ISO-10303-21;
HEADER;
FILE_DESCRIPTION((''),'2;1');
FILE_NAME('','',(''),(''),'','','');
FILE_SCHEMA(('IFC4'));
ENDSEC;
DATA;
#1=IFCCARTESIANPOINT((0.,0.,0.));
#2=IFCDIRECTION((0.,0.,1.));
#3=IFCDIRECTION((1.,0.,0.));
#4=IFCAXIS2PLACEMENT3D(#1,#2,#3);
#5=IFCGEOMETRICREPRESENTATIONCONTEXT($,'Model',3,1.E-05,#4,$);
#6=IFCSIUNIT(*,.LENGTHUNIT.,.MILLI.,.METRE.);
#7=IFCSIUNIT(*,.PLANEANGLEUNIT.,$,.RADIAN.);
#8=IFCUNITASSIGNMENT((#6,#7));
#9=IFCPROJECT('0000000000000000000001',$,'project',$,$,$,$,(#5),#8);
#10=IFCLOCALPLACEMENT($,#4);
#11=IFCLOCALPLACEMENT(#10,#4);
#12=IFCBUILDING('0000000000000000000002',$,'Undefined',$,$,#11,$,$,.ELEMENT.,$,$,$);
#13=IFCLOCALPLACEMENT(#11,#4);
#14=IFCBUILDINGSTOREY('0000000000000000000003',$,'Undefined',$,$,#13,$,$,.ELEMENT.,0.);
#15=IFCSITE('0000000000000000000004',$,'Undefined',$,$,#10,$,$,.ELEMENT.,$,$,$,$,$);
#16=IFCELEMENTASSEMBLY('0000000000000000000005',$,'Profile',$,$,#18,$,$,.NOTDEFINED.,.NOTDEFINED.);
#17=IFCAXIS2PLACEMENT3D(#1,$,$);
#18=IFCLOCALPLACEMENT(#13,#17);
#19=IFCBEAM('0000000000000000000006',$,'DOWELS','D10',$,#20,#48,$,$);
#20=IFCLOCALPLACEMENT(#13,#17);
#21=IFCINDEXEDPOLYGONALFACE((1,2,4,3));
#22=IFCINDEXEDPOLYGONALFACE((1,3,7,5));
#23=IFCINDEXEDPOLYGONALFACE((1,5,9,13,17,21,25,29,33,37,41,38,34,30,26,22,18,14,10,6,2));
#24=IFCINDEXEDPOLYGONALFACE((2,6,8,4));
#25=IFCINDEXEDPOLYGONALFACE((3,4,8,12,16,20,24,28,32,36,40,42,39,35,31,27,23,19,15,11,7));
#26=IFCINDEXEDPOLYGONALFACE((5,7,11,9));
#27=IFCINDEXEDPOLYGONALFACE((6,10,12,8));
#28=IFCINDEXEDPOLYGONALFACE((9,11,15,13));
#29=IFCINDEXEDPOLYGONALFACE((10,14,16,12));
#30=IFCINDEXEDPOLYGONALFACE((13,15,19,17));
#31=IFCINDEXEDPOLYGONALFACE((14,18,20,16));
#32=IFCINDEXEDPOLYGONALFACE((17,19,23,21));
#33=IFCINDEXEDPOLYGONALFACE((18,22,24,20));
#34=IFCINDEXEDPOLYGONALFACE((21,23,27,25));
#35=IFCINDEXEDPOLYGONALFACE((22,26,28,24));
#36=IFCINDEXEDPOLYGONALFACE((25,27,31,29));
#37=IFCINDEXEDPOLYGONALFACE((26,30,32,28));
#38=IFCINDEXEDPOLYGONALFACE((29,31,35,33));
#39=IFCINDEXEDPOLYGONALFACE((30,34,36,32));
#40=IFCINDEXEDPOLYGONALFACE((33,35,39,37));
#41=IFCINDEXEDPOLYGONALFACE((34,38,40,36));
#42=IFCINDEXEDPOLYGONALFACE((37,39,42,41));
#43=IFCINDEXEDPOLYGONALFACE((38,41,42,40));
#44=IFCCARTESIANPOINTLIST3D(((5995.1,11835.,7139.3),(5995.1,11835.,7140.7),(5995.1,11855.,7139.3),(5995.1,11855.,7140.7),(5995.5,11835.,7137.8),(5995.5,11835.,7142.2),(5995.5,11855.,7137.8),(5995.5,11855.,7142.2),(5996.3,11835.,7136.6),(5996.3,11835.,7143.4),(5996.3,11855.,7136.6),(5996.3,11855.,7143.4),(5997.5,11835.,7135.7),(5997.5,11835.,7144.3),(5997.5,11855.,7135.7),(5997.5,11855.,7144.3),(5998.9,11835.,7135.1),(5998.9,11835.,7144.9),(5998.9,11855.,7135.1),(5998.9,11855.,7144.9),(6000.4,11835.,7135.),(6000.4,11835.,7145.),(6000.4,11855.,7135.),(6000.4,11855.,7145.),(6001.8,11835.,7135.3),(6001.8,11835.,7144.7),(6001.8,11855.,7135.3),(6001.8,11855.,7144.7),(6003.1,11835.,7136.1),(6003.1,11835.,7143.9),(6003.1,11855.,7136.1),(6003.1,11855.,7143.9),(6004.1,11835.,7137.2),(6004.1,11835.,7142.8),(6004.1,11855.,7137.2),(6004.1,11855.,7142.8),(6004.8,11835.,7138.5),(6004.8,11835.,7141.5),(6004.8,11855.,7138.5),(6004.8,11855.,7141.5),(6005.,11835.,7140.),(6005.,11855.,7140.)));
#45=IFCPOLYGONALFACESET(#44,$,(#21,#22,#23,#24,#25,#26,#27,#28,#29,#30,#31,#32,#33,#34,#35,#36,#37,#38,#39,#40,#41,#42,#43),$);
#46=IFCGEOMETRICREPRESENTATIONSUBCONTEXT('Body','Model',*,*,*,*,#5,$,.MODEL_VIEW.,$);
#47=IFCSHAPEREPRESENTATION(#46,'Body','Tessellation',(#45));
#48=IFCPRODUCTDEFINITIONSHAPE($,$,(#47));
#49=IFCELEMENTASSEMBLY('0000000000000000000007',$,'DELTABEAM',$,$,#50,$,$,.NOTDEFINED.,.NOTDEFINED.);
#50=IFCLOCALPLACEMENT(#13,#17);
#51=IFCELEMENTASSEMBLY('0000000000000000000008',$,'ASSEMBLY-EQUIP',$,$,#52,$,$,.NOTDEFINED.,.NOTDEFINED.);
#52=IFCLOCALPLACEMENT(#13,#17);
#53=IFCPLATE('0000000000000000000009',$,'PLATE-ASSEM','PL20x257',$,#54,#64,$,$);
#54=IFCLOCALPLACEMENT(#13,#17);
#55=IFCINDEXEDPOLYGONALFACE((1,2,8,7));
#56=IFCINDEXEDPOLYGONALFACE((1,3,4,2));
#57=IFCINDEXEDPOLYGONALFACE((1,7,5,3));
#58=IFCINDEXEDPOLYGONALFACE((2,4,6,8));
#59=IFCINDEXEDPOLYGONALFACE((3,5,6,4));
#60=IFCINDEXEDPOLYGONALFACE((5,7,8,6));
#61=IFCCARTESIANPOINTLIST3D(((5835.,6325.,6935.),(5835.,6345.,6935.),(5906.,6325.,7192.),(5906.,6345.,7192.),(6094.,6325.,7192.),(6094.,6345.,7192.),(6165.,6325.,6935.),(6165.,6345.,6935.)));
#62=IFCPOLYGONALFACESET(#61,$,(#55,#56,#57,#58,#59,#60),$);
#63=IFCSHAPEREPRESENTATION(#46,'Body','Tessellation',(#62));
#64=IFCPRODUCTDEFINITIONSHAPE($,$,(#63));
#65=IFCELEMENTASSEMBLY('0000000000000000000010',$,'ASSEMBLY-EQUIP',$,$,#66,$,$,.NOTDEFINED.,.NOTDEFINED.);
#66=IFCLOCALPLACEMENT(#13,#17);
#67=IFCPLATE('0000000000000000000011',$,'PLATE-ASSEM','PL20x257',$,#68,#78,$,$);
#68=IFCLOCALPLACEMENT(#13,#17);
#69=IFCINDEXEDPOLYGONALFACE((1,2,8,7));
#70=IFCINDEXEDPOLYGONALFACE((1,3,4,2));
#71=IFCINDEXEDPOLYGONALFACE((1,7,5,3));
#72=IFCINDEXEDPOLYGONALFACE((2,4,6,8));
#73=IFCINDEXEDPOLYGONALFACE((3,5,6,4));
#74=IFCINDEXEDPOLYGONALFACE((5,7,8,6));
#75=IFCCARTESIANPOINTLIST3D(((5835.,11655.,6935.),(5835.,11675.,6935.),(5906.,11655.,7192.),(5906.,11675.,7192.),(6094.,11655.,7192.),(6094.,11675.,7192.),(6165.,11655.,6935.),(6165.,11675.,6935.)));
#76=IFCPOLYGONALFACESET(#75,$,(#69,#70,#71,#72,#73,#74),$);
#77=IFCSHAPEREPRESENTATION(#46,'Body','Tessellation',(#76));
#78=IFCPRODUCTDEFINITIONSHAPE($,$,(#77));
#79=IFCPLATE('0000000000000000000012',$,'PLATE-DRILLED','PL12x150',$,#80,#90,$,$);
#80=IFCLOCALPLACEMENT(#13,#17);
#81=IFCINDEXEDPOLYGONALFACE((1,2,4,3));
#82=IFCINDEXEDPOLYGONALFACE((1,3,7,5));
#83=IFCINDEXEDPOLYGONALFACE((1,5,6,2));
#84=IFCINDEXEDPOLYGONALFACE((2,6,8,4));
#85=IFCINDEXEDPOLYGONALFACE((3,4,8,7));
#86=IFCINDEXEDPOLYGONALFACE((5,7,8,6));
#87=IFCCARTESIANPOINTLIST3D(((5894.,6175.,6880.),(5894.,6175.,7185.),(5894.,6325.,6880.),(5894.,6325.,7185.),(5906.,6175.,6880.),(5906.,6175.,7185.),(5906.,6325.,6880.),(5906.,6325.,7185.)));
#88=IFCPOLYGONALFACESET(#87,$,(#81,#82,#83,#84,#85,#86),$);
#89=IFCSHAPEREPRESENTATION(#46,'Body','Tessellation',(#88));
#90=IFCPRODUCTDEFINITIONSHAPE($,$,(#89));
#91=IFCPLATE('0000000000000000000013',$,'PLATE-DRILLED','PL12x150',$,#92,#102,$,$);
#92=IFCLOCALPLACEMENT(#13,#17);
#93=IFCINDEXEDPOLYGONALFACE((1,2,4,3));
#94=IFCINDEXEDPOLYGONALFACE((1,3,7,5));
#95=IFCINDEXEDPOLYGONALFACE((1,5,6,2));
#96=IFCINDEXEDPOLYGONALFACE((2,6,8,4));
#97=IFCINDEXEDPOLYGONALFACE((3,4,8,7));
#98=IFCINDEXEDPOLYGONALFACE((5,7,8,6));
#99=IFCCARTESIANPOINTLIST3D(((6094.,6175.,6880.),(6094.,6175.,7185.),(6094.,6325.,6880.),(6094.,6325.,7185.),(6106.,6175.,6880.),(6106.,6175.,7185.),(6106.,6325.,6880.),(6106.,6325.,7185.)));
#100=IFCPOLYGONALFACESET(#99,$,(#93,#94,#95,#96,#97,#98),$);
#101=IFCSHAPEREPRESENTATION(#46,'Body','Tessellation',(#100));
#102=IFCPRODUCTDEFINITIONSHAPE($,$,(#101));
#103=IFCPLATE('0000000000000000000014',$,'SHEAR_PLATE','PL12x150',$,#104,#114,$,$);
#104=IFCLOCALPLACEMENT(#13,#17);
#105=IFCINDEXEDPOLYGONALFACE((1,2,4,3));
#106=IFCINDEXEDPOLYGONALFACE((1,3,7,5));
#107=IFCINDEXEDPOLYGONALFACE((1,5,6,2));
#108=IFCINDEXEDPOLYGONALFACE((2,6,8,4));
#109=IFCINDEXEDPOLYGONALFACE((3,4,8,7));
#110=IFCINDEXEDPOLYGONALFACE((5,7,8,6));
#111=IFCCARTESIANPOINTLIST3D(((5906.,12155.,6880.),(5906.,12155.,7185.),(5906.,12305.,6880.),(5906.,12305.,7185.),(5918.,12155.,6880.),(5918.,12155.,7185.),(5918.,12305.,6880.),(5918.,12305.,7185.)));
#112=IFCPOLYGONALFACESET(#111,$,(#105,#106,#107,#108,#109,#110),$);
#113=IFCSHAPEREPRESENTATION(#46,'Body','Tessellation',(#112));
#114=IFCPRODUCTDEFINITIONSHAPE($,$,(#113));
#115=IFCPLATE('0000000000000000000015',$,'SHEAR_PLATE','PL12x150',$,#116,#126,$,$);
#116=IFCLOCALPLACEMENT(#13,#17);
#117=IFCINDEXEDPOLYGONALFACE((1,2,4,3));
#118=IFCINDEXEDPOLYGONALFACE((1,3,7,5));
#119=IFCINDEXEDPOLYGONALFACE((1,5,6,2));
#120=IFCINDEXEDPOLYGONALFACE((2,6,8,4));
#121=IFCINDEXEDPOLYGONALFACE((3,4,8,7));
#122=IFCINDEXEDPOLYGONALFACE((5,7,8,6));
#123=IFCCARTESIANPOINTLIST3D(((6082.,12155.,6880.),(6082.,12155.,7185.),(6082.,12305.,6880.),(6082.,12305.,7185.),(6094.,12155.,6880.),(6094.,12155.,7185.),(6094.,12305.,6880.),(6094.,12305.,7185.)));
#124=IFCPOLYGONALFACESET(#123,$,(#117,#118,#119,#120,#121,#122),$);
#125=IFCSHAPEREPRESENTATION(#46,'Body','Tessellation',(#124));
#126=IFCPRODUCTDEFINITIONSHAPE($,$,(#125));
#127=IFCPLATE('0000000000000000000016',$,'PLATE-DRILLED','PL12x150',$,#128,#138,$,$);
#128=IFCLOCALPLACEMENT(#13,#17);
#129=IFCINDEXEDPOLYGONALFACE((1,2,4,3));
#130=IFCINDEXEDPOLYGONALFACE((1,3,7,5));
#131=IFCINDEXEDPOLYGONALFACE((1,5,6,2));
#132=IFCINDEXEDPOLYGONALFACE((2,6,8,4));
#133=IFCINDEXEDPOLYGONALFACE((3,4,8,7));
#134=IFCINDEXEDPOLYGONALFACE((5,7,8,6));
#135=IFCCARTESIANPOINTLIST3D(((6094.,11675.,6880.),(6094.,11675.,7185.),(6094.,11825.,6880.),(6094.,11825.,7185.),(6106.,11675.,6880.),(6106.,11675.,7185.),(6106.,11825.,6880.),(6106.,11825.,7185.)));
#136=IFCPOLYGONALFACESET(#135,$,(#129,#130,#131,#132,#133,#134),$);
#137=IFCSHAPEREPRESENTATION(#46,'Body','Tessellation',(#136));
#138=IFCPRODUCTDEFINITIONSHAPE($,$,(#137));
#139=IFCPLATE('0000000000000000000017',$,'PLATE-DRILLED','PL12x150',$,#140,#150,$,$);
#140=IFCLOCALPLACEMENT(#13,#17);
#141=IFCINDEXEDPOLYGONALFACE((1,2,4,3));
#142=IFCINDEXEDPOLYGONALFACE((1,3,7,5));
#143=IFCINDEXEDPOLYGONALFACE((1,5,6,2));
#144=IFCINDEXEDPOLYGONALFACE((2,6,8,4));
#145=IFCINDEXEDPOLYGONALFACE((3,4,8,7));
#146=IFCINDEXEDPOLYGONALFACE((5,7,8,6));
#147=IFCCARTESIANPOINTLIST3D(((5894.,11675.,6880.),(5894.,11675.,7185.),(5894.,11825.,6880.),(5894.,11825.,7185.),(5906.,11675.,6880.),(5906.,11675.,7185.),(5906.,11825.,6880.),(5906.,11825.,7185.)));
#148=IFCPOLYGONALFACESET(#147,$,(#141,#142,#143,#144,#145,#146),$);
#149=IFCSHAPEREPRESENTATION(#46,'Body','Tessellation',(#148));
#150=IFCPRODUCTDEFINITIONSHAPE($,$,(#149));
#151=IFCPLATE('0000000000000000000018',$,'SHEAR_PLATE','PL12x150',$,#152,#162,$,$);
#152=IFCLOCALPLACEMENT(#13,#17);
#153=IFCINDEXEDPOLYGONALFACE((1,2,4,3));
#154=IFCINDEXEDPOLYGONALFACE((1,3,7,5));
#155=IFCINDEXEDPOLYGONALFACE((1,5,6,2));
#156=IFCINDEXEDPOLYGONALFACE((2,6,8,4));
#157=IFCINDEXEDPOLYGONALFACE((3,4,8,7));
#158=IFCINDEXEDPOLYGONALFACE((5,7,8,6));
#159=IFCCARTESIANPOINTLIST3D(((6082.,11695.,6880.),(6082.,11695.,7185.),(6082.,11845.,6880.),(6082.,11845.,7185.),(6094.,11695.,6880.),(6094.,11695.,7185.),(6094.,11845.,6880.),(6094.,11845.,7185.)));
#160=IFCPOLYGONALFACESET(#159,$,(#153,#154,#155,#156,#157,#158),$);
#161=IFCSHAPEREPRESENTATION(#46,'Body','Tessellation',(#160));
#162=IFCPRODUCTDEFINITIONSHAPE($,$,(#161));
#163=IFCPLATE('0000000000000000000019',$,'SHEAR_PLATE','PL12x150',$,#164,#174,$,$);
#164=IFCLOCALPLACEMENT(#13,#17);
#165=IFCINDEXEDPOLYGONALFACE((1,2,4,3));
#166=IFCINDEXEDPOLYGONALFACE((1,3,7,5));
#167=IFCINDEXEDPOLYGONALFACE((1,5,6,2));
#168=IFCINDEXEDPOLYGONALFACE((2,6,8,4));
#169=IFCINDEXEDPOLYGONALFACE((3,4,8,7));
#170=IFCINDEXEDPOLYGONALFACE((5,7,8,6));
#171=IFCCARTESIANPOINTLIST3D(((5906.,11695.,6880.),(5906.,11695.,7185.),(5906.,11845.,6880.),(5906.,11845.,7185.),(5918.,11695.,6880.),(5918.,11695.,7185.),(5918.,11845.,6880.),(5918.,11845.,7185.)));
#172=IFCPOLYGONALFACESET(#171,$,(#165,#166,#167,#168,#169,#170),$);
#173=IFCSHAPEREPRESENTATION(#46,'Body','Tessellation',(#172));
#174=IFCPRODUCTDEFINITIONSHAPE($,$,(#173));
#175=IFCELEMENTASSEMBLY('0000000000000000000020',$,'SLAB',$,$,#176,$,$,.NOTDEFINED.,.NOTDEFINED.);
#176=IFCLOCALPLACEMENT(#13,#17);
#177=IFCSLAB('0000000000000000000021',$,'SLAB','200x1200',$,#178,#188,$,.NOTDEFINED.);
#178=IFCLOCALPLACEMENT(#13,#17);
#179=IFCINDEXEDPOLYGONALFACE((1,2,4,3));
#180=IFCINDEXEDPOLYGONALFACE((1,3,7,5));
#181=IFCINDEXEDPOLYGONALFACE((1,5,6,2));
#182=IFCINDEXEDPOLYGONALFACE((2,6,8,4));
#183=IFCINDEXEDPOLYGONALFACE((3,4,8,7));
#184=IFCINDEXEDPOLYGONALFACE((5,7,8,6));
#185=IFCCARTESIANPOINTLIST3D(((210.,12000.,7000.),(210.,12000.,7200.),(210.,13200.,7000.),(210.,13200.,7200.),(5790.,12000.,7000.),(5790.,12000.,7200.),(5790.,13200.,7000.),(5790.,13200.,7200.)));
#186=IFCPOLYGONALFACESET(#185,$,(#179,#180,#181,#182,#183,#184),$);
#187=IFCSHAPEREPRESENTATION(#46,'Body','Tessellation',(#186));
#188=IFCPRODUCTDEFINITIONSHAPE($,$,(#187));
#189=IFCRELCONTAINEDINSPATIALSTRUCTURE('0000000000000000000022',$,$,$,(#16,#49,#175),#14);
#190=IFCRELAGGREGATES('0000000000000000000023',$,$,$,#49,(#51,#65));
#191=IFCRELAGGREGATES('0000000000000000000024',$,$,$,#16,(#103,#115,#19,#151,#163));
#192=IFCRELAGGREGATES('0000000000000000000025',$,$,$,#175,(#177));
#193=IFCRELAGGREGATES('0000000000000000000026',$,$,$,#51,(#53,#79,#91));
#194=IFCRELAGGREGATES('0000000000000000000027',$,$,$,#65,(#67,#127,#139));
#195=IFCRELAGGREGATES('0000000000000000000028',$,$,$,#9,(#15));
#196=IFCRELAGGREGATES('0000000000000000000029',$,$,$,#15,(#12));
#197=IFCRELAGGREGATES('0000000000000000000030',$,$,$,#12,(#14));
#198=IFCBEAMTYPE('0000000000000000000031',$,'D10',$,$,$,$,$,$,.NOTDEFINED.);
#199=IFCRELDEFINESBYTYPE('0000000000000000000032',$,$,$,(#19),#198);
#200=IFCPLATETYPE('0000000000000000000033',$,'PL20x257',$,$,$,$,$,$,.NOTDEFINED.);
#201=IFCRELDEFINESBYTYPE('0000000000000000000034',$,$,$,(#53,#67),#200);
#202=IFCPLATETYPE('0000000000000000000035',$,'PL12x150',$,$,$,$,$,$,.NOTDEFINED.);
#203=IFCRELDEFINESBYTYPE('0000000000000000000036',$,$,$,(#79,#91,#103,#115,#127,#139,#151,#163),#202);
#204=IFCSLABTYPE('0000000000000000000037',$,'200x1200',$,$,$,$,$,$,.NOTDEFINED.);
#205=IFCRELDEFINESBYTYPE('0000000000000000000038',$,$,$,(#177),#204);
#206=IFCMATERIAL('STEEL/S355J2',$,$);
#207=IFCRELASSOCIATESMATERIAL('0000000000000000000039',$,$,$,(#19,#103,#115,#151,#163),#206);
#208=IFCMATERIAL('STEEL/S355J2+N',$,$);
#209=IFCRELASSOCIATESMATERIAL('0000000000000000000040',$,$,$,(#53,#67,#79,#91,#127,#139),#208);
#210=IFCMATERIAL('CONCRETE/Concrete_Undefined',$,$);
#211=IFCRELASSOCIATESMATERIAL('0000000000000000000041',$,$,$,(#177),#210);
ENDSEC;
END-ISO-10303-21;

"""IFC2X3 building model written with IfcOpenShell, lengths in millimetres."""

from ifc_helpers import new_model, si_unit, frame, origin_with_axes, origin_2d_with_axis, place, context, subcontext, project, spatial, polyline, circle, outline, extrude, material, type_object, element, aggregate, save


model = new_model("IFC2X3")

# Units and contexts
model_context = context("Model", 3, precision=1e-05, world=origin_with_axes())
body_context = subcontext(model_context, "Body", "Model", "MODEL_VIEW")
ifc_project = project(units=[si_unit("LENGTHUNIT", "METRE", prefix="MILLI"), si_unit("PLANEANGLEUNIT", "RADIAN")], contexts=[model_context])

# Site, building, storey
site_placement = place(None, origin_with_axes())
site = spatial("IfcSite", under=ifc_project, at=site_placement, Name="Undefined", CompositionType="ELEMENT")
building_placement = place(site_placement, origin_with_axes())
building = spatial("IfcBuilding", under=site, at=building_placement, Name="Undefined", CompositionType="ELEMENT")
storey_placement = place(building_placement, origin_with_axes())
storey = spatial("IfcBuildingStorey", under=building, at=storey_placement, Name="Undefined", CompositionType="ELEMENT", Elevation=0.0)

# Element assembly, beam
assembly_1_placement = place(storey_placement, origin_with_axes())
assembly_1 = element("IfcElementAssembly", 1, at=assembly_1_placement, inside=storey, Name="Profile", AssemblyPlace="NOTDEFINED", PredefinedType="NOTDEFINED")
ifc_material_1 = material(Name="STEEL/S355J2")
beam_type_1 = type_object("IfcBeamType", Name="D10", PredefinedType="NOTDEFINED")
beam_1_placement = place(assembly_1_placement, frame((6000.0, 11835.0, 7140.0), z_axis=(0.0, 0.0, 1.0), x_axis=(0.0, 1.0, 0.0)))
beam_1 = element("IfcBeam", 2, at=beam_1_placement, type_object=beam_type_1, material=ifc_material_1, Name="DOWELS", Description="D10", context=body_context, shape_type="SweptSolid", body=[
    extrude(circle(Radius=5.0, at=origin_2d_with_axis()), frame((20.0, 0.0, 0.0), z_axis=(-1.0, 0.0, 0.0), x_axis=(0.0, -1.0, 0.0)), (0.0, 0.0, 1.0), 20.0),
])

# Element assemblies, plates
assembly_2_placement = place(storey_placement, origin_with_axes())
assembly_2 = element("IfcElementAssembly", 3, at=assembly_2_placement, inside=storey, Name="DELTABEAM", AssemblyPlace="NOTDEFINED", PredefinedType="NOTDEFINED")
assembly_3_placement = place(assembly_2_placement, origin_with_axes())
assembly_3 = element("IfcElementAssembly", 4, at=assembly_3_placement, Name="ASSEMBLY-EQUIP", AssemblyPlace="NOTDEFINED", PredefinedType="NOTDEFINED")
ifc_material_2 = material(Name="STEEL/S355J2+N")
plate_type_1 = type_object("IfcPlateType", Name="PL20x257", PredefinedType="NOTDEFINED")
plate_1_placement = place(assembly_3_placement, frame((6165.0, 6335.0, 6935.0), z_axis=(0.0, 1.0, 0.0), x_axis=(-1.0, 0.0, 0.0)))
plate_1 = element("IfcPlate", 5, at=plate_1_placement, type_object=plate_type_1, material=ifc_material_2, Name="PLATE-ASSEM", Description="PL20x257", context=body_context, shape_type="SweptSolid", body=[
    extrude(outline(polyline([(0.0, 0.0), (330.0, 0.0), (259.0, 257.0), (71.0, 257.0), (0.0, 0.0)])), frame((0.0, 0.0, -10.0), z_axis=(0.0, 0.0, 1.0), x_axis=(1.0, 0.0, 0.0)), (0.0, 0.0, 1.0), 20.0),
])
assembly_4_placement = place(assembly_2_placement, origin_with_axes())
assembly_4 = element("IfcElementAssembly", 6, at=assembly_4_placement, Name="ASSEMBLY-EQUIP", AssemblyPlace="NOTDEFINED", PredefinedType="NOTDEFINED")
aggregate(assembly_2, [assembly_3, assembly_4])
plate_2_placement = place(assembly_4_placement, frame((5835.0, 11665.0, 6935.0), z_axis=(0.0, -1.0, 0.0), x_axis=(1.0, 0.0, 0.0)))
plate_2 = element("IfcPlate", 7, at=plate_2_placement, type_object=plate_type_1, material=ifc_material_2, Name="PLATE-ASSEM", Description="PL20x257", context=body_context, shape_type="SweptSolid", body=[
    extrude(outline(polyline([(0.0, 0.0), (330.0, 0.0), (259.0, 257.0), (71.0, 257.0), (0.0, 0.0)])), frame((0.0, 0.0, -10.0), z_axis=(0.0, 0.0, 1.0), x_axis=(1.0, 0.0, 0.0)), (0.0, 0.0, 1.0), 20.0),
])
plate_type_2 = type_object("IfcPlateType", Name="PL12x150", PredefinedType="NOTDEFINED")
plate_3_placement = place(assembly_3_placement, frame((5900.0, 6325.0, 7185.0), z_axis=(1.0, 0.0, 0.0), x_axis=(0.0, -1.0, 0.0)))
plate_3 = element("IfcPlate", 8, at=plate_3_placement, type_object=plate_type_2, material=ifc_material_2, Name="PLATE-DRILLED", Description="PL12x150", context=body_context, shape_type="SweptSolid", body=[
    extrude(outline(polyline([(0.0, 0.0), (150.0, 0.0), (150.0, 0.0), (150.0, 305.0), (150.0, 305.0), (0.0, 305.0), (0.0, 305.0), (0.0, 0.0)])), frame((0.0, 0.0, -6.0), z_axis=(0.0, 0.0, 1.0), x_axis=(1.0, 0.0, 0.0)), (0.0, 0.0, 1.0), 12.0),
])
plate_4_placement = place(assembly_3_placement, frame((6100.0, 6325.0, 7185.0), z_axis=(1.0, 0.0, 0.0), x_axis=(0.0, -1.0, 0.0)))
plate_4 = element("IfcPlate", 9, at=plate_4_placement, type_object=plate_type_2, material=ifc_material_2, Name="PLATE-DRILLED", Description="PL12x150", context=body_context, shape_type="SweptSolid", body=[
    extrude(outline(polyline([(0.0, 0.0), (150.0, 0.0), (150.0, 0.0), (150.0, 305.0), (150.0, 305.0), (0.0, 305.0), (0.0, 305.0), (0.0, 0.0)])), frame((0.0, 0.0, -6.0), z_axis=(0.0, 0.0, 1.0), x_axis=(1.0, 0.0, 0.0)), (0.0, 0.0, 1.0), 12.0),
])

# Plates
plate_5_placement = place(assembly_1_placement, frame((5912.0, 12155.0, 7185.0), z_axis=(-1.0, 0.0, 0.0), x_axis=(0.0, 1.0, 0.0)))
plate_5 = element("IfcPlate", 10, at=plate_5_placement, type_object=plate_type_2, material=ifc_material_1, Name="SHEAR_PLATE", Description="PL12x150", context=body_context, shape_type="SweptSolid", body=[
    extrude(outline(polyline([(0.0, 0.0), (150.0, 0.0), (150.0, 0.0), (150.0, 305.0), (150.0, 305.0), (0.0, 305.0), (0.0, 305.0), (0.0, 0.0)])), frame((0.0, 0.0, -6.0), z_axis=(0.0, 0.0, 1.0), x_axis=(1.0, 0.0, 0.0)), (0.0, 0.0, 1.0), 12.0),
])
plate_6_placement = place(assembly_1_placement, frame((6088.0, 12155.0, 7185.0), z_axis=(-1.0, 0.0, 0.0), x_axis=(0.0, 1.0, 0.0)))
plate_6 = element("IfcPlate", 11, at=plate_6_placement, type_object=plate_type_2, material=ifc_material_1, Name="SHEAR_PLATE", Description="PL12x150", context=body_context, shape_type="SweptSolid", body=[
    extrude(outline(polyline([(0.0, 0.0), (150.0, 0.0), (150.0, 0.0), (150.0, 305.0), (150.0, 305.0), (0.0, 305.0), (0.0, 305.0), (0.0, 0.0)])), frame((0.0, 0.0, -6.0), z_axis=(0.0, 0.0, 1.0), x_axis=(1.0, 0.0, 0.0)), (0.0, 0.0, 1.0), 12.0),
])
plate_7_placement = place(assembly_4_placement, frame((6100.0, 11675.0, 7185.0), z_axis=(-1.0, 0.0, 0.0), x_axis=(0.0, 1.0, 0.0)))
plate_7 = element("IfcPlate", 12, at=plate_7_placement, type_object=plate_type_2, material=ifc_material_2, Name="PLATE-DRILLED", Description="PL12x150", context=body_context, shape_type="SweptSolid", body=[
    extrude(outline(polyline([(0.0, 0.0), (150.0, 0.0), (150.0, 0.0), (150.0, 305.0), (150.0, 305.0), (0.0, 305.0), (0.0, 305.0), (0.0, 0.0)])), frame((0.0, 0.0, -6.0), z_axis=(0.0, 0.0, 1.0), x_axis=(1.0, 0.0, 0.0)), (0.0, 0.0, 1.0), 12.0),
])
plate_8_placement = place(assembly_4_placement, frame((5900.0, 11675.0, 7185.0), z_axis=(-1.0, 0.0, 0.0), x_axis=(0.0, 1.0, 0.0)))
plate_8 = element("IfcPlate", 13, at=plate_8_placement, type_object=plate_type_2, material=ifc_material_2, Name="PLATE-DRILLED", Description="PL12x150", context=body_context, shape_type="SweptSolid", body=[
    extrude(outline(polyline([(0.0, 0.0), (150.0, 0.0), (150.0, 0.0), (150.0, 305.0), (150.0, 305.0), (0.0, 305.0), (0.0, 305.0), (0.0, 0.0)])), frame((0.0, 0.0, -6.0), z_axis=(0.0, 0.0, 1.0), x_axis=(1.0, 0.0, 0.0)), (0.0, 0.0, 1.0), 12.0),
])
plate_9_placement = place(assembly_1_placement, frame((6088.0, 11845.0, 7185.0), z_axis=(1.0, 0.0, 0.0), x_axis=(0.0, -1.0, 0.0)))
plate_9 = element("IfcPlate", 14, at=plate_9_placement, type_object=plate_type_2, material=ifc_material_1, Name="SHEAR_PLATE", Description="PL12x150", context=body_context, shape_type="SweptSolid", body=[
    extrude(outline(polyline([(0.0, 0.0), (150.0, 0.0), (150.0, 0.0), (150.0, 305.0), (150.0, 305.0), (0.0, 305.0), (0.0, 305.0), (0.0, 0.0)])), frame((0.0, 0.0, -6.0), z_axis=(0.0, 0.0, 1.0), x_axis=(1.0, 0.0, 0.0)), (0.0, 0.0, 1.0), 12.0),
])
plate_10_placement = place(assembly_1_placement, frame((5912.0, 11845.0, 7185.0), z_axis=(1.0, 0.0, 0.0), x_axis=(0.0, -1.0, 0.0)))
plate_10 = element("IfcPlate", 15, at=plate_10_placement, type_object=plate_type_2, material=ifc_material_1, Name="SHEAR_PLATE", Description="PL12x150", context=body_context, shape_type="SweptSolid", body=[
    extrude(outline(polyline([(0.0, 0.0), (150.0, 0.0), (150.0, 0.0), (150.0, 305.0), (150.0, 305.0), (0.0, 305.0), (0.0, 305.0), (0.0, 0.0)])), frame((0.0, 0.0, -6.0), z_axis=(0.0, 0.0, 1.0), x_axis=(1.0, 0.0, 0.0)), (0.0, 0.0, 1.0), 12.0),
])
aggregate(assembly_1, [plate_5, plate_6, beam_1, plate_9, plate_10])

# Element assembly, slab
assembly_5_placement = place(storey_placement, origin_with_axes())
assembly_5 = element("IfcElementAssembly", 16, at=assembly_5_placement, inside=storey, Name="SLAB", AssemblyPlace="NOTDEFINED", PredefinedType="NOTDEFINED")
ifc_material_3 = material(Name="CONCRETE/Concrete_Undefined")
slab_type = type_object("IfcSlabType", Name="200x1200", PredefinedType="NOTDEFINED")
slab_placement = place(assembly_5_placement, frame((5790.0, 12000.0, 7100.0), z_axis=(0.0, 0.0, 1.0), x_axis=(0.0, 1.0, 0.0)))
slab = element("IfcSlab", 17, at=slab_placement, type_object=slab_type, material=ifc_material_3, Name="SLAB", Description="200x1200", PredefinedType="NOTDEFINED", context=body_context, shape_type="SweptSolid", body=[
    extrude(outline(polyline([(0.0, 0.0), (1200.0, 0.0), (1200.0, 5580.0), (0.0, 5580.0), (0.0, 0.0)])), frame((0.0, 0.0, -100.0), z_axis=(0.0, 0.0, 1.0), x_axis=(1.0, 0.0, 0.0)), (0.0, 0.0, 1.0), 200.0),
])
aggregate(assembly_5, [slab])

aggregate(assembly_3, [plate_1, plate_3, plate_4])
aggregate(assembly_4, [plate_2, plate_7, plate_8])

save(model, "model.ifc")
